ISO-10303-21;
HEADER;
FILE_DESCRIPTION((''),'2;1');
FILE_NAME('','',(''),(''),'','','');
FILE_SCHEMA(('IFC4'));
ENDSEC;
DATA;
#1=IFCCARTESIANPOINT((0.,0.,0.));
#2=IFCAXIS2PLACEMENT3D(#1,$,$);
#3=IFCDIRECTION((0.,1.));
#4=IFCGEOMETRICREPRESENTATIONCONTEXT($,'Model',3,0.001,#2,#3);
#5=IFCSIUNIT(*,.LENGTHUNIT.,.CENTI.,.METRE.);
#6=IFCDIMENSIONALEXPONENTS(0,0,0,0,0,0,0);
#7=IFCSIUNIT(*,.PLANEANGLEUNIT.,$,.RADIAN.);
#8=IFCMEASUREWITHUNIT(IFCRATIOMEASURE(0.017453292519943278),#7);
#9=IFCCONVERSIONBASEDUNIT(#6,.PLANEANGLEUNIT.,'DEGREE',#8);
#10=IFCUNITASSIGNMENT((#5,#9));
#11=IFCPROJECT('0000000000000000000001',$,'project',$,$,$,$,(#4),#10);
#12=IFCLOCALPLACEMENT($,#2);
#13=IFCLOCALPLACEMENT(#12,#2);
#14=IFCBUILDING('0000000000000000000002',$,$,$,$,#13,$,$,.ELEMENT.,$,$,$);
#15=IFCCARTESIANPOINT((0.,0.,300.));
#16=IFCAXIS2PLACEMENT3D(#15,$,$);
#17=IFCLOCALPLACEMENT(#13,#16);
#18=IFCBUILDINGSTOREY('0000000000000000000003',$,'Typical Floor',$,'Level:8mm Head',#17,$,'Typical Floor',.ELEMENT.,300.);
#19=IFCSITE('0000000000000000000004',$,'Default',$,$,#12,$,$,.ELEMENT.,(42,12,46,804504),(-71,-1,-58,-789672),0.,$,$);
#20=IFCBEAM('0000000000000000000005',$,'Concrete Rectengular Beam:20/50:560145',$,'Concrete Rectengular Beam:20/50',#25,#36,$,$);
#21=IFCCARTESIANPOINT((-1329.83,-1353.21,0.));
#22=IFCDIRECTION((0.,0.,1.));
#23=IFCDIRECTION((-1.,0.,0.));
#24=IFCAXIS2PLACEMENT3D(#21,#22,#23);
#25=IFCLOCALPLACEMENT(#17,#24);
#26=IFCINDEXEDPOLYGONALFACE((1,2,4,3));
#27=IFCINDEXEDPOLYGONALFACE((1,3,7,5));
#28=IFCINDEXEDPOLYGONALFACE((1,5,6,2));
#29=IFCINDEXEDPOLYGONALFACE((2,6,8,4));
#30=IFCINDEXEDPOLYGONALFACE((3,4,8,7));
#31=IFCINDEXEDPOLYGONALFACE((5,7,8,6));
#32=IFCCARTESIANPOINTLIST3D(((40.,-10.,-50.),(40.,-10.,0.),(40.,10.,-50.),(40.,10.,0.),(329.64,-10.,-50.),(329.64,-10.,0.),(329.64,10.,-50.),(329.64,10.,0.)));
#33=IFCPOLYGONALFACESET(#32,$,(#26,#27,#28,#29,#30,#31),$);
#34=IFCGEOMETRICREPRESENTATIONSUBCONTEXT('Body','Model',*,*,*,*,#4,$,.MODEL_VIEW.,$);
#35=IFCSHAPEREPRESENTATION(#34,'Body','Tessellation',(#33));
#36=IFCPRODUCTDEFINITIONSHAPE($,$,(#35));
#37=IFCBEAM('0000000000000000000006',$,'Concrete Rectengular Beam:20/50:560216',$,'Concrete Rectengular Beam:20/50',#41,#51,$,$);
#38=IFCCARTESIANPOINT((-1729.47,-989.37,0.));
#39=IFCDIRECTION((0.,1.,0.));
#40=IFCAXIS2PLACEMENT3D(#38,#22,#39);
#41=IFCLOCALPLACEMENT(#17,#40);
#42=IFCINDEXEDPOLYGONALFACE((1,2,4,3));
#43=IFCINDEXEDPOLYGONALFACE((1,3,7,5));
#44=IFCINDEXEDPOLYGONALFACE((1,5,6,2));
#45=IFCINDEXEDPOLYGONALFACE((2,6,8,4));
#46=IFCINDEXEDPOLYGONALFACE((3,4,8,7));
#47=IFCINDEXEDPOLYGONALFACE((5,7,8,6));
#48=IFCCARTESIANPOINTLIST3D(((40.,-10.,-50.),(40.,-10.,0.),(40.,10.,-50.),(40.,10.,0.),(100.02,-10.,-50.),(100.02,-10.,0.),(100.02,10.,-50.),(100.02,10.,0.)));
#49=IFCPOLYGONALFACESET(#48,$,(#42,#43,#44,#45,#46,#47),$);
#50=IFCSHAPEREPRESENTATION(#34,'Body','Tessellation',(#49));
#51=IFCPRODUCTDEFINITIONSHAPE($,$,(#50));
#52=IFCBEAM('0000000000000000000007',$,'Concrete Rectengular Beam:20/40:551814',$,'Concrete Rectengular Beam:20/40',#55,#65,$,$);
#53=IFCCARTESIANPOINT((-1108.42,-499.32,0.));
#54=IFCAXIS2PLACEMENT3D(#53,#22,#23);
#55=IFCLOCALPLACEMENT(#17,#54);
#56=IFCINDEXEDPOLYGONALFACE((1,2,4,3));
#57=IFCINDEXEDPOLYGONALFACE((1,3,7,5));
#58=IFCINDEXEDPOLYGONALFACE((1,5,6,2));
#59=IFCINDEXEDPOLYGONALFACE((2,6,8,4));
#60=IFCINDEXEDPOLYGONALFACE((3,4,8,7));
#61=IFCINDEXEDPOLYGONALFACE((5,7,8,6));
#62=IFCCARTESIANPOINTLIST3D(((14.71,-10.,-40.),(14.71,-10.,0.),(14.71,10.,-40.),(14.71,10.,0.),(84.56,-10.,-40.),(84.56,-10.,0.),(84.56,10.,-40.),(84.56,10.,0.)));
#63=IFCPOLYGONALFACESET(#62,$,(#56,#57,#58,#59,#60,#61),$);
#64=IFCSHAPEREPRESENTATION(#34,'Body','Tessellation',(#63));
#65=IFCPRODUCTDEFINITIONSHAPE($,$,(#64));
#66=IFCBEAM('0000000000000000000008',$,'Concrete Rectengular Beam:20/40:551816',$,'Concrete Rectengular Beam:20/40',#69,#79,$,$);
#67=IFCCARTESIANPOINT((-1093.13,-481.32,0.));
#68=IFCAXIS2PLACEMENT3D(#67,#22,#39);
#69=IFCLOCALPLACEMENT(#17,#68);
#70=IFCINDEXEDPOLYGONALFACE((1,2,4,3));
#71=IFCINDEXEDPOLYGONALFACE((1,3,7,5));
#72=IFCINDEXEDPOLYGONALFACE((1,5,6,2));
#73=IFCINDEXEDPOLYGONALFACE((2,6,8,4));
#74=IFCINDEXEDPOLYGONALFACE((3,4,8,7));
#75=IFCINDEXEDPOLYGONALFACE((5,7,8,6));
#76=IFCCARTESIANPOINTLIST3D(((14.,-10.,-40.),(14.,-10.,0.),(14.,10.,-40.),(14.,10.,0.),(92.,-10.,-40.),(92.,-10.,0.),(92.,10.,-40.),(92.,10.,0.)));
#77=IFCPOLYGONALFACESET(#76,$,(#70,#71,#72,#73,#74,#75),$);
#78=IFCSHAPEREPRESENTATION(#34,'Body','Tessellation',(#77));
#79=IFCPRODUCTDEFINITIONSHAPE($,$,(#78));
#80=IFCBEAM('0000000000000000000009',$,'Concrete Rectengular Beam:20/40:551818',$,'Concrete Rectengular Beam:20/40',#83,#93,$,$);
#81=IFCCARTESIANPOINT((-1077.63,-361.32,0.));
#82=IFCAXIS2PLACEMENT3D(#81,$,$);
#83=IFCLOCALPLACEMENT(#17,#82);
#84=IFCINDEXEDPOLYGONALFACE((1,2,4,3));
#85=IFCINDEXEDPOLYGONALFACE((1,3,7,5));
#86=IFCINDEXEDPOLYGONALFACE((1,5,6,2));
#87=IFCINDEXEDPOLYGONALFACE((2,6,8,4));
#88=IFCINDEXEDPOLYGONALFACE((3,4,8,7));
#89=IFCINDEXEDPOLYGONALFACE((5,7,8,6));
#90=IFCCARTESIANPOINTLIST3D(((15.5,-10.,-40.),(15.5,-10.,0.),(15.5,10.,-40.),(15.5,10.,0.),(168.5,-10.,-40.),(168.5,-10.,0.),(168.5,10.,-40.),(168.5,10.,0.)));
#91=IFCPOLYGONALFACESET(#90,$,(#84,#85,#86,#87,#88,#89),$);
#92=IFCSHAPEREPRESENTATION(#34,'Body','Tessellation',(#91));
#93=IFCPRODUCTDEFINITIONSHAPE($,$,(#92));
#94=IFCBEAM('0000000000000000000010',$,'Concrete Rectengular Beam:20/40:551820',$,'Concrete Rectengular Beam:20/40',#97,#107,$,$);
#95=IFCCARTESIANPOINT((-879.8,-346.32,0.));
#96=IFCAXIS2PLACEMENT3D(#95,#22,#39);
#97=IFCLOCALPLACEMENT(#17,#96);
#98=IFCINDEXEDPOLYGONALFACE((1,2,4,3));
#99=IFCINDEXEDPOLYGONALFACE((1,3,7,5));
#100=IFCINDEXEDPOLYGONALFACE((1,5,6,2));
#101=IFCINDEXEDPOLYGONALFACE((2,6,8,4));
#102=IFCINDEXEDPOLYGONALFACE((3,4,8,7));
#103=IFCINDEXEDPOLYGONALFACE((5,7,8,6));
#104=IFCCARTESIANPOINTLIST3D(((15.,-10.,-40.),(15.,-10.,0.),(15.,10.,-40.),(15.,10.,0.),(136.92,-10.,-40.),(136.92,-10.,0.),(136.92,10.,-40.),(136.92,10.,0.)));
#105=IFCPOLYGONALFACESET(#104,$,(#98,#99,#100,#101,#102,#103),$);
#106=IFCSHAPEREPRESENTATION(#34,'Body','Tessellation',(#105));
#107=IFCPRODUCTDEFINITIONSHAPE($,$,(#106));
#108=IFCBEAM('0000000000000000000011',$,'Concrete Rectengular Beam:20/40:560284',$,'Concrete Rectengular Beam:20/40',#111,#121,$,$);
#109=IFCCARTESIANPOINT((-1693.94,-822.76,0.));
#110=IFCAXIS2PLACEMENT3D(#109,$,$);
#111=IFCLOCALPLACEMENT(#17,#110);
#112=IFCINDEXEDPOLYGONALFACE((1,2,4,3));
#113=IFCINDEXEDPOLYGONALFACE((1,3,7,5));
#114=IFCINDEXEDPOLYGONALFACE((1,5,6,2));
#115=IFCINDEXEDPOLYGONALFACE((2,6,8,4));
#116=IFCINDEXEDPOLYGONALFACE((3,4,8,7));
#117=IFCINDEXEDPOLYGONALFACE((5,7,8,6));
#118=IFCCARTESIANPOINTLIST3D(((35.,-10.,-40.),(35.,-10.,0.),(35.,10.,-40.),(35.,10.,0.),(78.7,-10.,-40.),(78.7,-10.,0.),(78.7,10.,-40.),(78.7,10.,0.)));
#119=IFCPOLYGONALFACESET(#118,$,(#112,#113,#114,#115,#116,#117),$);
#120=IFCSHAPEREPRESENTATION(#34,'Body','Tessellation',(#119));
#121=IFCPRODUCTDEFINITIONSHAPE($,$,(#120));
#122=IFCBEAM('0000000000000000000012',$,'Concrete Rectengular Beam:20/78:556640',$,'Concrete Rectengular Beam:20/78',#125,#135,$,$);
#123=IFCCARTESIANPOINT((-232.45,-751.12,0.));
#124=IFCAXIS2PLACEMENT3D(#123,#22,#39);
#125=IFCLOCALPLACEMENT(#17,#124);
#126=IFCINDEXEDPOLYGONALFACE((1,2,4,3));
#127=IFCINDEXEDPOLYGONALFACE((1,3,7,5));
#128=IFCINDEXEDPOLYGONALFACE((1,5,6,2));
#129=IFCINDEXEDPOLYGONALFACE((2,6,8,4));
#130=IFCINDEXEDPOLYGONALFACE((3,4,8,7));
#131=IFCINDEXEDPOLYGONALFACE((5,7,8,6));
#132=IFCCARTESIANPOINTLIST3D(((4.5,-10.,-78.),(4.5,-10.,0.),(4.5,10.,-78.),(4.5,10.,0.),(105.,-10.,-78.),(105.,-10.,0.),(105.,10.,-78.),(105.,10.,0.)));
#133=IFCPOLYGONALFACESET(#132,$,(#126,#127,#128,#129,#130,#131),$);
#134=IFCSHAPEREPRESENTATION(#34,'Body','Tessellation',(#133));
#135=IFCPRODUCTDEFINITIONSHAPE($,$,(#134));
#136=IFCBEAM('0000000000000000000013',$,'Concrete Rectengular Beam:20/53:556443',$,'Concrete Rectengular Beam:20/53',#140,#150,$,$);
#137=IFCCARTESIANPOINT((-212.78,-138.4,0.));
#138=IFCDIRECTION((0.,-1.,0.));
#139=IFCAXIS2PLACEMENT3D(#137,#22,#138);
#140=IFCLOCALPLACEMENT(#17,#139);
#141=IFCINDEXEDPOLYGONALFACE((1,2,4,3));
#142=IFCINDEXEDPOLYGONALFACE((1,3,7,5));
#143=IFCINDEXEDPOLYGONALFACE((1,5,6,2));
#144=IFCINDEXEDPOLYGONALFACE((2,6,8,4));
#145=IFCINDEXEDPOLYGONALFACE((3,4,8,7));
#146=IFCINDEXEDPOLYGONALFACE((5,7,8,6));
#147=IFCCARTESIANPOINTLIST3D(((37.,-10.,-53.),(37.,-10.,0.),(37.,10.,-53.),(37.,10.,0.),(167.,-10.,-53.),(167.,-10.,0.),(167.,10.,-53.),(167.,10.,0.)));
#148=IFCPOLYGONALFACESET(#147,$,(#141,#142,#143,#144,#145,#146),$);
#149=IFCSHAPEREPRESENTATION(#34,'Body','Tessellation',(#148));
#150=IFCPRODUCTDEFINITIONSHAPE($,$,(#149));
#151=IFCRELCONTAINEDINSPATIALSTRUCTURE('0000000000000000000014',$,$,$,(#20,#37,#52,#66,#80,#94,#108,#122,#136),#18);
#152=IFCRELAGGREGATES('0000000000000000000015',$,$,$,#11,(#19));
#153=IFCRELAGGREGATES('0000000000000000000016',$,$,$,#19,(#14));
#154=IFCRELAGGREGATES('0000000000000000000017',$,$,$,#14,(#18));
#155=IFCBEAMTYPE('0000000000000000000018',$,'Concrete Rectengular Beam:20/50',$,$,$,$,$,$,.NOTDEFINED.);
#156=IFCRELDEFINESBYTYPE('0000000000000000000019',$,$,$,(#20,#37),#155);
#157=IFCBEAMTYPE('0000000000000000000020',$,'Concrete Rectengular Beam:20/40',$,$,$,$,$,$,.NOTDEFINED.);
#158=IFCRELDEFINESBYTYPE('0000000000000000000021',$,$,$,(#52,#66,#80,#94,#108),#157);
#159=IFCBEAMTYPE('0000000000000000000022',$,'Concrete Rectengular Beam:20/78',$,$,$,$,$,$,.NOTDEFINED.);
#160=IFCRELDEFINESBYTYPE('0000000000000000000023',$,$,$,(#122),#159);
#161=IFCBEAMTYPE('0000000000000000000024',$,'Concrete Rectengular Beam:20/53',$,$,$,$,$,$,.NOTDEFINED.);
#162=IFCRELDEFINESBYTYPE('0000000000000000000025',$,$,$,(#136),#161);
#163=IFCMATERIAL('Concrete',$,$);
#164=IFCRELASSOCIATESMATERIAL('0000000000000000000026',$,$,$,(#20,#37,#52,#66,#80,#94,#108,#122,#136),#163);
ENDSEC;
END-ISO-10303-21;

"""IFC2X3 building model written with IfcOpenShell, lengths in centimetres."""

from ifc_helpers import new_model, entity, si_unit, converted_unit, direction, frame, frame_2d, origin, origin_2d_with_axis, place, context, subcontext, project, spatial, rectangle, extrude, material, type_object, element, save


model = new_model("IFC2X3")

# Units and contexts
model_context = context("Model", 3, precision=0.001, world=origin(), true_north=direction((0.0, 1.0)))
body_context = subcontext(model_context, "Body", "Model", "MODEL_VIEW")
ifc_project = project(units=[si_unit("LENGTHUNIT", "METRE", prefix="CENTI"), converted_unit("PLANEANGLEUNIT", "DEGREE", entity("IfcRatioMeasure", 0.017453292519943278), si_unit("PLANEANGLEUNIT", "RADIAN"), dimensions=[0, 0, 0, 0, 0, 0, 0])], contexts=[model_context])

# Site, building, storey
site_placement = place(None, origin())
site = spatial("IfcSite", under=ifc_project, at=site_placement, Name="Default", CompositionType="ELEMENT", RefLatitude=(42, 12, 46, 804504), RefLongitude=(-71, -1, -58, -789672), RefElevation=0.0)
building_placement = place(site_placement, origin())
building = spatial("IfcBuilding", under=site, at=building_placement, CompositionType="ELEMENT")
storey_placement = place(building_placement, frame((0.0, 0.0, 300.0)))
storey = spatial("IfcBuildingStorey", under=building, at=storey_placement, Name="Typical Floor", ObjectType="Level:8mm Head", LongName="Typical Floor", CompositionType="ELEMENT", Elevation=300.0)

# Beams
ifc_material = material(Name="Concrete")
beam_type_1 = type_object("IfcBeamType", Name="Concrete Rectengular Beam:20/50", PredefinedType="NOTDEFINED")
beam_1_placement = place(storey_placement, frame((-1329.83, -1353.21, 0.0), z_axis=(0.0, 0.0, 1.0), x_axis=(-1.0, 0.0, 0.0)))
element("IfcBeam", 1, at=beam_1_placement, inside=storey, type_object=beam_type_1, material=ifc_material, Name="Concrete Rectengular Beam:20/50:560145", ObjectType="Concrete Rectengular Beam:20/50", context=body_context, shape_type="SweptSolid", body=[
    extrude(rectangle(XDim=50.0, YDim=20.0, at=frame_2d((0.0, 0.0), x_axis=(1.0, 0.0))), frame((40.0, 0.0, -25.0), z_axis=(1.0, 0.0, 0.0), x_axis=(0.0, 0.0, -1.0)), (0.0, 0.0, 1.0), 289.64),
])
beam_2_placement = place(storey_placement, frame((-1729.47, -989.37, 0.0), z_axis=(0.0, 0.0, 1.0), x_axis=(0.0, 1.0, 0.0)))
element("IfcBeam", 2, at=beam_2_placement, inside=storey, type_object=beam_type_1, material=ifc_material, Name="Concrete Rectengular Beam:20/50:560216", ObjectType="Concrete Rectengular Beam:20/50", context=body_context, shape_type="SweptSolid", body=[
    extrude(rectangle(XDim=50.0, YDim=20.0, at=frame_2d((0.0, 0.0), x_axis=(1.0, 0.0))), frame((40.0, 0.0, -25.0), z_axis=(1.0, 0.0, 0.0), x_axis=(0.0, 0.0, -1.0)), (0.0, 0.0, 1.0), 60.02),
])
beam_type_2 = type_object("IfcBeamType", Name="Concrete Rectengular Beam:20/40", PredefinedType="NOTDEFINED")
beam_3_placement = place(storey_placement, frame((-1108.42, -499.32, 0.0), z_axis=(0.0, 0.0, 1.0), x_axis=(-1.0, 0.0, 0.0)))
element("IfcBeam", 3, at=beam_3_placement, inside=storey, type_object=beam_type_2, material=ifc_material, Name="Concrete Rectengular Beam:20/40:551814", ObjectType="Concrete Rectengular Beam:20/40", context=body_context, shape_type="SweptSolid", body=[
    extrude(rectangle(XDim=40.0, YDim=20.0, at=frame_2d((0.0, 0.0), x_axis=(1.0, 0.0))), frame((14.71, 0.0, -20.0), z_axis=(1.0, 0.0, 0.0), x_axis=(0.0, 0.0, -1.0)), (0.0, 0.0, 1.0), 69.85),
])
beam_4_placement = place(storey_placement, frame((-1093.13, -481.32, 0.0), z_axis=(0.0, 0.0, 1.0), x_axis=(0.0, 1.0, 0.0)))
element("IfcBeam", 4, at=beam_4_placement, inside=storey, type_object=beam_type_2, material=ifc_material, Name="Concrete Rectengular Beam:20/40:551816", ObjectType="Concrete Rectengular Beam:20/40", context=body_context, shape_type="SweptSolid", body=[
    extrude(rectangle(XDim=40.0, YDim=20.0, at=origin_2d_with_axis()), frame((14.0, 0.0, -20.0), z_axis=(1.0, 0.0, 0.0), x_axis=(0.0, 0.0, -1.0)), (0.0, 0.0, 1.0), 78.0),
])
beam_5_placement = place(storey_placement, frame((-1077.63, -361.32, 0.0)))
element("IfcBeam", 5, at=beam_5_placement, inside=storey, type_object=beam_type_2, material=ifc_material, Name="Concrete Rectengular Beam:20/40:551818", ObjectType="Concrete Rectengular Beam:20/40", context=body_context, shape_type="SweptSolid", body=[
    extrude(rectangle(XDim=40.0, YDim=20.0, at=frame_2d((0.0, 0.0), x_axis=(1.0, 0.0))), frame((15.5, 0.0, -20.0), z_axis=(1.0, 0.0, 0.0), x_axis=(0.0, 0.0, -1.0)), (0.0, 0.0, 1.0), 153.0),
])
beam_6_placement = place(storey_placement, frame((-879.8, -346.32, 0.0), z_axis=(0.0, 0.0, 1.0), x_axis=(0.0, 1.0, 0.0)))
element("IfcBeam", 6, at=beam_6_placement, inside=storey, type_object=beam_type_2, material=ifc_material, Name="Concrete Rectengular Beam:20/40:551820", ObjectType="Concrete Rectengular Beam:20/40", context=body_context, shape_type="SweptSolid", body=[
    extrude(rectangle(XDim=40.0, YDim=20.0, at=frame_2d((0.0, 0.0), x_axis=(1.0, 0.0))), frame((15.0, 0.0, -20.0), z_axis=(1.0, 0.0, 0.0), x_axis=(0.0, 0.0, -1.0)), (0.0, 0.0, 1.0), 121.92),
])
beam_7_placement = place(storey_placement, frame((-1693.94, -822.76, 0.0)))
element("IfcBeam", 7, at=beam_7_placement, inside=storey, type_object=beam_type_2, material=ifc_material, Name="Concrete Rectengular Beam:20/40:560284", ObjectType="Concrete Rectengular Beam:20/40", context=body_context, shape_type="SweptSolid", body=[
    extrude(rectangle(XDim=40.0, YDim=20.0, at=frame_2d((0.0, 0.0), x_axis=(1.0, 0.0))), frame((35.0, 0.0, -20.0), z_axis=(1.0, 0.0, 0.0), x_axis=(0.0, 0.0, -1.0)), (0.0, 0.0, 1.0), 43.7),
])
beam_type_3 = type_object("IfcBeamType", Name="Concrete Rectengular Beam:20/78", PredefinedType="NOTDEFINED")
beam_8_placement = place(storey_placement, frame((-232.45, -751.12, 0.0), z_axis=(0.0, 0.0, 1.0), x_axis=(0.0, 1.0, 0.0)))
element("IfcBeam", 8, at=beam_8_placement, inside=storey, type_object=beam_type_3, material=ifc_material, Name="Concrete Rectengular Beam:20/78:556640", ObjectType="Concrete Rectengular Beam:20/78", context=body_context, shape_type="SweptSolid", body=[
    extrude(rectangle(XDim=78.0, YDim=20.0, at=frame_2d((0.0, 0.0), x_axis=(1.0, 0.0))), frame((4.5, 0.0, -39.0), z_axis=(1.0, 0.0, 0.0), x_axis=(0.0, 0.0, -1.0)), (0.0, 0.0, 1.0), 100.5),
])
beam_type_4 = type_object("IfcBeamType", Name="Concrete Rectengular Beam:20/53", PredefinedType="NOTDEFINED")
beam_9_placement = place(storey_placement, frame((-212.78, -138.4, 0.0), z_axis=(0.0, 0.0, 1.0), x_axis=(0.0, -1.0, 0.0)))
element("IfcBeam", 9, at=beam_9_placement, inside=storey, type_object=beam_type_4, material=ifc_material, Name="Concrete Rectengular Beam:20/53:556443", ObjectType="Concrete Rectengular Beam:20/53", context=body_context, shape_type="SweptSolid", body=[
    extrude(rectangle(XDim=53.0, YDim=20.0, at=frame_2d((0.0, 0.0), x_axis=(1.0, 0.0))), frame((37.0, 0.0, -26.5), z_axis=(1.0, 0.0, 0.0), x_axis=(0.0, 0.0, -1.0)), (0.0, 0.0, 1.0), 130.0),
])

save(model, "model.ifc")
